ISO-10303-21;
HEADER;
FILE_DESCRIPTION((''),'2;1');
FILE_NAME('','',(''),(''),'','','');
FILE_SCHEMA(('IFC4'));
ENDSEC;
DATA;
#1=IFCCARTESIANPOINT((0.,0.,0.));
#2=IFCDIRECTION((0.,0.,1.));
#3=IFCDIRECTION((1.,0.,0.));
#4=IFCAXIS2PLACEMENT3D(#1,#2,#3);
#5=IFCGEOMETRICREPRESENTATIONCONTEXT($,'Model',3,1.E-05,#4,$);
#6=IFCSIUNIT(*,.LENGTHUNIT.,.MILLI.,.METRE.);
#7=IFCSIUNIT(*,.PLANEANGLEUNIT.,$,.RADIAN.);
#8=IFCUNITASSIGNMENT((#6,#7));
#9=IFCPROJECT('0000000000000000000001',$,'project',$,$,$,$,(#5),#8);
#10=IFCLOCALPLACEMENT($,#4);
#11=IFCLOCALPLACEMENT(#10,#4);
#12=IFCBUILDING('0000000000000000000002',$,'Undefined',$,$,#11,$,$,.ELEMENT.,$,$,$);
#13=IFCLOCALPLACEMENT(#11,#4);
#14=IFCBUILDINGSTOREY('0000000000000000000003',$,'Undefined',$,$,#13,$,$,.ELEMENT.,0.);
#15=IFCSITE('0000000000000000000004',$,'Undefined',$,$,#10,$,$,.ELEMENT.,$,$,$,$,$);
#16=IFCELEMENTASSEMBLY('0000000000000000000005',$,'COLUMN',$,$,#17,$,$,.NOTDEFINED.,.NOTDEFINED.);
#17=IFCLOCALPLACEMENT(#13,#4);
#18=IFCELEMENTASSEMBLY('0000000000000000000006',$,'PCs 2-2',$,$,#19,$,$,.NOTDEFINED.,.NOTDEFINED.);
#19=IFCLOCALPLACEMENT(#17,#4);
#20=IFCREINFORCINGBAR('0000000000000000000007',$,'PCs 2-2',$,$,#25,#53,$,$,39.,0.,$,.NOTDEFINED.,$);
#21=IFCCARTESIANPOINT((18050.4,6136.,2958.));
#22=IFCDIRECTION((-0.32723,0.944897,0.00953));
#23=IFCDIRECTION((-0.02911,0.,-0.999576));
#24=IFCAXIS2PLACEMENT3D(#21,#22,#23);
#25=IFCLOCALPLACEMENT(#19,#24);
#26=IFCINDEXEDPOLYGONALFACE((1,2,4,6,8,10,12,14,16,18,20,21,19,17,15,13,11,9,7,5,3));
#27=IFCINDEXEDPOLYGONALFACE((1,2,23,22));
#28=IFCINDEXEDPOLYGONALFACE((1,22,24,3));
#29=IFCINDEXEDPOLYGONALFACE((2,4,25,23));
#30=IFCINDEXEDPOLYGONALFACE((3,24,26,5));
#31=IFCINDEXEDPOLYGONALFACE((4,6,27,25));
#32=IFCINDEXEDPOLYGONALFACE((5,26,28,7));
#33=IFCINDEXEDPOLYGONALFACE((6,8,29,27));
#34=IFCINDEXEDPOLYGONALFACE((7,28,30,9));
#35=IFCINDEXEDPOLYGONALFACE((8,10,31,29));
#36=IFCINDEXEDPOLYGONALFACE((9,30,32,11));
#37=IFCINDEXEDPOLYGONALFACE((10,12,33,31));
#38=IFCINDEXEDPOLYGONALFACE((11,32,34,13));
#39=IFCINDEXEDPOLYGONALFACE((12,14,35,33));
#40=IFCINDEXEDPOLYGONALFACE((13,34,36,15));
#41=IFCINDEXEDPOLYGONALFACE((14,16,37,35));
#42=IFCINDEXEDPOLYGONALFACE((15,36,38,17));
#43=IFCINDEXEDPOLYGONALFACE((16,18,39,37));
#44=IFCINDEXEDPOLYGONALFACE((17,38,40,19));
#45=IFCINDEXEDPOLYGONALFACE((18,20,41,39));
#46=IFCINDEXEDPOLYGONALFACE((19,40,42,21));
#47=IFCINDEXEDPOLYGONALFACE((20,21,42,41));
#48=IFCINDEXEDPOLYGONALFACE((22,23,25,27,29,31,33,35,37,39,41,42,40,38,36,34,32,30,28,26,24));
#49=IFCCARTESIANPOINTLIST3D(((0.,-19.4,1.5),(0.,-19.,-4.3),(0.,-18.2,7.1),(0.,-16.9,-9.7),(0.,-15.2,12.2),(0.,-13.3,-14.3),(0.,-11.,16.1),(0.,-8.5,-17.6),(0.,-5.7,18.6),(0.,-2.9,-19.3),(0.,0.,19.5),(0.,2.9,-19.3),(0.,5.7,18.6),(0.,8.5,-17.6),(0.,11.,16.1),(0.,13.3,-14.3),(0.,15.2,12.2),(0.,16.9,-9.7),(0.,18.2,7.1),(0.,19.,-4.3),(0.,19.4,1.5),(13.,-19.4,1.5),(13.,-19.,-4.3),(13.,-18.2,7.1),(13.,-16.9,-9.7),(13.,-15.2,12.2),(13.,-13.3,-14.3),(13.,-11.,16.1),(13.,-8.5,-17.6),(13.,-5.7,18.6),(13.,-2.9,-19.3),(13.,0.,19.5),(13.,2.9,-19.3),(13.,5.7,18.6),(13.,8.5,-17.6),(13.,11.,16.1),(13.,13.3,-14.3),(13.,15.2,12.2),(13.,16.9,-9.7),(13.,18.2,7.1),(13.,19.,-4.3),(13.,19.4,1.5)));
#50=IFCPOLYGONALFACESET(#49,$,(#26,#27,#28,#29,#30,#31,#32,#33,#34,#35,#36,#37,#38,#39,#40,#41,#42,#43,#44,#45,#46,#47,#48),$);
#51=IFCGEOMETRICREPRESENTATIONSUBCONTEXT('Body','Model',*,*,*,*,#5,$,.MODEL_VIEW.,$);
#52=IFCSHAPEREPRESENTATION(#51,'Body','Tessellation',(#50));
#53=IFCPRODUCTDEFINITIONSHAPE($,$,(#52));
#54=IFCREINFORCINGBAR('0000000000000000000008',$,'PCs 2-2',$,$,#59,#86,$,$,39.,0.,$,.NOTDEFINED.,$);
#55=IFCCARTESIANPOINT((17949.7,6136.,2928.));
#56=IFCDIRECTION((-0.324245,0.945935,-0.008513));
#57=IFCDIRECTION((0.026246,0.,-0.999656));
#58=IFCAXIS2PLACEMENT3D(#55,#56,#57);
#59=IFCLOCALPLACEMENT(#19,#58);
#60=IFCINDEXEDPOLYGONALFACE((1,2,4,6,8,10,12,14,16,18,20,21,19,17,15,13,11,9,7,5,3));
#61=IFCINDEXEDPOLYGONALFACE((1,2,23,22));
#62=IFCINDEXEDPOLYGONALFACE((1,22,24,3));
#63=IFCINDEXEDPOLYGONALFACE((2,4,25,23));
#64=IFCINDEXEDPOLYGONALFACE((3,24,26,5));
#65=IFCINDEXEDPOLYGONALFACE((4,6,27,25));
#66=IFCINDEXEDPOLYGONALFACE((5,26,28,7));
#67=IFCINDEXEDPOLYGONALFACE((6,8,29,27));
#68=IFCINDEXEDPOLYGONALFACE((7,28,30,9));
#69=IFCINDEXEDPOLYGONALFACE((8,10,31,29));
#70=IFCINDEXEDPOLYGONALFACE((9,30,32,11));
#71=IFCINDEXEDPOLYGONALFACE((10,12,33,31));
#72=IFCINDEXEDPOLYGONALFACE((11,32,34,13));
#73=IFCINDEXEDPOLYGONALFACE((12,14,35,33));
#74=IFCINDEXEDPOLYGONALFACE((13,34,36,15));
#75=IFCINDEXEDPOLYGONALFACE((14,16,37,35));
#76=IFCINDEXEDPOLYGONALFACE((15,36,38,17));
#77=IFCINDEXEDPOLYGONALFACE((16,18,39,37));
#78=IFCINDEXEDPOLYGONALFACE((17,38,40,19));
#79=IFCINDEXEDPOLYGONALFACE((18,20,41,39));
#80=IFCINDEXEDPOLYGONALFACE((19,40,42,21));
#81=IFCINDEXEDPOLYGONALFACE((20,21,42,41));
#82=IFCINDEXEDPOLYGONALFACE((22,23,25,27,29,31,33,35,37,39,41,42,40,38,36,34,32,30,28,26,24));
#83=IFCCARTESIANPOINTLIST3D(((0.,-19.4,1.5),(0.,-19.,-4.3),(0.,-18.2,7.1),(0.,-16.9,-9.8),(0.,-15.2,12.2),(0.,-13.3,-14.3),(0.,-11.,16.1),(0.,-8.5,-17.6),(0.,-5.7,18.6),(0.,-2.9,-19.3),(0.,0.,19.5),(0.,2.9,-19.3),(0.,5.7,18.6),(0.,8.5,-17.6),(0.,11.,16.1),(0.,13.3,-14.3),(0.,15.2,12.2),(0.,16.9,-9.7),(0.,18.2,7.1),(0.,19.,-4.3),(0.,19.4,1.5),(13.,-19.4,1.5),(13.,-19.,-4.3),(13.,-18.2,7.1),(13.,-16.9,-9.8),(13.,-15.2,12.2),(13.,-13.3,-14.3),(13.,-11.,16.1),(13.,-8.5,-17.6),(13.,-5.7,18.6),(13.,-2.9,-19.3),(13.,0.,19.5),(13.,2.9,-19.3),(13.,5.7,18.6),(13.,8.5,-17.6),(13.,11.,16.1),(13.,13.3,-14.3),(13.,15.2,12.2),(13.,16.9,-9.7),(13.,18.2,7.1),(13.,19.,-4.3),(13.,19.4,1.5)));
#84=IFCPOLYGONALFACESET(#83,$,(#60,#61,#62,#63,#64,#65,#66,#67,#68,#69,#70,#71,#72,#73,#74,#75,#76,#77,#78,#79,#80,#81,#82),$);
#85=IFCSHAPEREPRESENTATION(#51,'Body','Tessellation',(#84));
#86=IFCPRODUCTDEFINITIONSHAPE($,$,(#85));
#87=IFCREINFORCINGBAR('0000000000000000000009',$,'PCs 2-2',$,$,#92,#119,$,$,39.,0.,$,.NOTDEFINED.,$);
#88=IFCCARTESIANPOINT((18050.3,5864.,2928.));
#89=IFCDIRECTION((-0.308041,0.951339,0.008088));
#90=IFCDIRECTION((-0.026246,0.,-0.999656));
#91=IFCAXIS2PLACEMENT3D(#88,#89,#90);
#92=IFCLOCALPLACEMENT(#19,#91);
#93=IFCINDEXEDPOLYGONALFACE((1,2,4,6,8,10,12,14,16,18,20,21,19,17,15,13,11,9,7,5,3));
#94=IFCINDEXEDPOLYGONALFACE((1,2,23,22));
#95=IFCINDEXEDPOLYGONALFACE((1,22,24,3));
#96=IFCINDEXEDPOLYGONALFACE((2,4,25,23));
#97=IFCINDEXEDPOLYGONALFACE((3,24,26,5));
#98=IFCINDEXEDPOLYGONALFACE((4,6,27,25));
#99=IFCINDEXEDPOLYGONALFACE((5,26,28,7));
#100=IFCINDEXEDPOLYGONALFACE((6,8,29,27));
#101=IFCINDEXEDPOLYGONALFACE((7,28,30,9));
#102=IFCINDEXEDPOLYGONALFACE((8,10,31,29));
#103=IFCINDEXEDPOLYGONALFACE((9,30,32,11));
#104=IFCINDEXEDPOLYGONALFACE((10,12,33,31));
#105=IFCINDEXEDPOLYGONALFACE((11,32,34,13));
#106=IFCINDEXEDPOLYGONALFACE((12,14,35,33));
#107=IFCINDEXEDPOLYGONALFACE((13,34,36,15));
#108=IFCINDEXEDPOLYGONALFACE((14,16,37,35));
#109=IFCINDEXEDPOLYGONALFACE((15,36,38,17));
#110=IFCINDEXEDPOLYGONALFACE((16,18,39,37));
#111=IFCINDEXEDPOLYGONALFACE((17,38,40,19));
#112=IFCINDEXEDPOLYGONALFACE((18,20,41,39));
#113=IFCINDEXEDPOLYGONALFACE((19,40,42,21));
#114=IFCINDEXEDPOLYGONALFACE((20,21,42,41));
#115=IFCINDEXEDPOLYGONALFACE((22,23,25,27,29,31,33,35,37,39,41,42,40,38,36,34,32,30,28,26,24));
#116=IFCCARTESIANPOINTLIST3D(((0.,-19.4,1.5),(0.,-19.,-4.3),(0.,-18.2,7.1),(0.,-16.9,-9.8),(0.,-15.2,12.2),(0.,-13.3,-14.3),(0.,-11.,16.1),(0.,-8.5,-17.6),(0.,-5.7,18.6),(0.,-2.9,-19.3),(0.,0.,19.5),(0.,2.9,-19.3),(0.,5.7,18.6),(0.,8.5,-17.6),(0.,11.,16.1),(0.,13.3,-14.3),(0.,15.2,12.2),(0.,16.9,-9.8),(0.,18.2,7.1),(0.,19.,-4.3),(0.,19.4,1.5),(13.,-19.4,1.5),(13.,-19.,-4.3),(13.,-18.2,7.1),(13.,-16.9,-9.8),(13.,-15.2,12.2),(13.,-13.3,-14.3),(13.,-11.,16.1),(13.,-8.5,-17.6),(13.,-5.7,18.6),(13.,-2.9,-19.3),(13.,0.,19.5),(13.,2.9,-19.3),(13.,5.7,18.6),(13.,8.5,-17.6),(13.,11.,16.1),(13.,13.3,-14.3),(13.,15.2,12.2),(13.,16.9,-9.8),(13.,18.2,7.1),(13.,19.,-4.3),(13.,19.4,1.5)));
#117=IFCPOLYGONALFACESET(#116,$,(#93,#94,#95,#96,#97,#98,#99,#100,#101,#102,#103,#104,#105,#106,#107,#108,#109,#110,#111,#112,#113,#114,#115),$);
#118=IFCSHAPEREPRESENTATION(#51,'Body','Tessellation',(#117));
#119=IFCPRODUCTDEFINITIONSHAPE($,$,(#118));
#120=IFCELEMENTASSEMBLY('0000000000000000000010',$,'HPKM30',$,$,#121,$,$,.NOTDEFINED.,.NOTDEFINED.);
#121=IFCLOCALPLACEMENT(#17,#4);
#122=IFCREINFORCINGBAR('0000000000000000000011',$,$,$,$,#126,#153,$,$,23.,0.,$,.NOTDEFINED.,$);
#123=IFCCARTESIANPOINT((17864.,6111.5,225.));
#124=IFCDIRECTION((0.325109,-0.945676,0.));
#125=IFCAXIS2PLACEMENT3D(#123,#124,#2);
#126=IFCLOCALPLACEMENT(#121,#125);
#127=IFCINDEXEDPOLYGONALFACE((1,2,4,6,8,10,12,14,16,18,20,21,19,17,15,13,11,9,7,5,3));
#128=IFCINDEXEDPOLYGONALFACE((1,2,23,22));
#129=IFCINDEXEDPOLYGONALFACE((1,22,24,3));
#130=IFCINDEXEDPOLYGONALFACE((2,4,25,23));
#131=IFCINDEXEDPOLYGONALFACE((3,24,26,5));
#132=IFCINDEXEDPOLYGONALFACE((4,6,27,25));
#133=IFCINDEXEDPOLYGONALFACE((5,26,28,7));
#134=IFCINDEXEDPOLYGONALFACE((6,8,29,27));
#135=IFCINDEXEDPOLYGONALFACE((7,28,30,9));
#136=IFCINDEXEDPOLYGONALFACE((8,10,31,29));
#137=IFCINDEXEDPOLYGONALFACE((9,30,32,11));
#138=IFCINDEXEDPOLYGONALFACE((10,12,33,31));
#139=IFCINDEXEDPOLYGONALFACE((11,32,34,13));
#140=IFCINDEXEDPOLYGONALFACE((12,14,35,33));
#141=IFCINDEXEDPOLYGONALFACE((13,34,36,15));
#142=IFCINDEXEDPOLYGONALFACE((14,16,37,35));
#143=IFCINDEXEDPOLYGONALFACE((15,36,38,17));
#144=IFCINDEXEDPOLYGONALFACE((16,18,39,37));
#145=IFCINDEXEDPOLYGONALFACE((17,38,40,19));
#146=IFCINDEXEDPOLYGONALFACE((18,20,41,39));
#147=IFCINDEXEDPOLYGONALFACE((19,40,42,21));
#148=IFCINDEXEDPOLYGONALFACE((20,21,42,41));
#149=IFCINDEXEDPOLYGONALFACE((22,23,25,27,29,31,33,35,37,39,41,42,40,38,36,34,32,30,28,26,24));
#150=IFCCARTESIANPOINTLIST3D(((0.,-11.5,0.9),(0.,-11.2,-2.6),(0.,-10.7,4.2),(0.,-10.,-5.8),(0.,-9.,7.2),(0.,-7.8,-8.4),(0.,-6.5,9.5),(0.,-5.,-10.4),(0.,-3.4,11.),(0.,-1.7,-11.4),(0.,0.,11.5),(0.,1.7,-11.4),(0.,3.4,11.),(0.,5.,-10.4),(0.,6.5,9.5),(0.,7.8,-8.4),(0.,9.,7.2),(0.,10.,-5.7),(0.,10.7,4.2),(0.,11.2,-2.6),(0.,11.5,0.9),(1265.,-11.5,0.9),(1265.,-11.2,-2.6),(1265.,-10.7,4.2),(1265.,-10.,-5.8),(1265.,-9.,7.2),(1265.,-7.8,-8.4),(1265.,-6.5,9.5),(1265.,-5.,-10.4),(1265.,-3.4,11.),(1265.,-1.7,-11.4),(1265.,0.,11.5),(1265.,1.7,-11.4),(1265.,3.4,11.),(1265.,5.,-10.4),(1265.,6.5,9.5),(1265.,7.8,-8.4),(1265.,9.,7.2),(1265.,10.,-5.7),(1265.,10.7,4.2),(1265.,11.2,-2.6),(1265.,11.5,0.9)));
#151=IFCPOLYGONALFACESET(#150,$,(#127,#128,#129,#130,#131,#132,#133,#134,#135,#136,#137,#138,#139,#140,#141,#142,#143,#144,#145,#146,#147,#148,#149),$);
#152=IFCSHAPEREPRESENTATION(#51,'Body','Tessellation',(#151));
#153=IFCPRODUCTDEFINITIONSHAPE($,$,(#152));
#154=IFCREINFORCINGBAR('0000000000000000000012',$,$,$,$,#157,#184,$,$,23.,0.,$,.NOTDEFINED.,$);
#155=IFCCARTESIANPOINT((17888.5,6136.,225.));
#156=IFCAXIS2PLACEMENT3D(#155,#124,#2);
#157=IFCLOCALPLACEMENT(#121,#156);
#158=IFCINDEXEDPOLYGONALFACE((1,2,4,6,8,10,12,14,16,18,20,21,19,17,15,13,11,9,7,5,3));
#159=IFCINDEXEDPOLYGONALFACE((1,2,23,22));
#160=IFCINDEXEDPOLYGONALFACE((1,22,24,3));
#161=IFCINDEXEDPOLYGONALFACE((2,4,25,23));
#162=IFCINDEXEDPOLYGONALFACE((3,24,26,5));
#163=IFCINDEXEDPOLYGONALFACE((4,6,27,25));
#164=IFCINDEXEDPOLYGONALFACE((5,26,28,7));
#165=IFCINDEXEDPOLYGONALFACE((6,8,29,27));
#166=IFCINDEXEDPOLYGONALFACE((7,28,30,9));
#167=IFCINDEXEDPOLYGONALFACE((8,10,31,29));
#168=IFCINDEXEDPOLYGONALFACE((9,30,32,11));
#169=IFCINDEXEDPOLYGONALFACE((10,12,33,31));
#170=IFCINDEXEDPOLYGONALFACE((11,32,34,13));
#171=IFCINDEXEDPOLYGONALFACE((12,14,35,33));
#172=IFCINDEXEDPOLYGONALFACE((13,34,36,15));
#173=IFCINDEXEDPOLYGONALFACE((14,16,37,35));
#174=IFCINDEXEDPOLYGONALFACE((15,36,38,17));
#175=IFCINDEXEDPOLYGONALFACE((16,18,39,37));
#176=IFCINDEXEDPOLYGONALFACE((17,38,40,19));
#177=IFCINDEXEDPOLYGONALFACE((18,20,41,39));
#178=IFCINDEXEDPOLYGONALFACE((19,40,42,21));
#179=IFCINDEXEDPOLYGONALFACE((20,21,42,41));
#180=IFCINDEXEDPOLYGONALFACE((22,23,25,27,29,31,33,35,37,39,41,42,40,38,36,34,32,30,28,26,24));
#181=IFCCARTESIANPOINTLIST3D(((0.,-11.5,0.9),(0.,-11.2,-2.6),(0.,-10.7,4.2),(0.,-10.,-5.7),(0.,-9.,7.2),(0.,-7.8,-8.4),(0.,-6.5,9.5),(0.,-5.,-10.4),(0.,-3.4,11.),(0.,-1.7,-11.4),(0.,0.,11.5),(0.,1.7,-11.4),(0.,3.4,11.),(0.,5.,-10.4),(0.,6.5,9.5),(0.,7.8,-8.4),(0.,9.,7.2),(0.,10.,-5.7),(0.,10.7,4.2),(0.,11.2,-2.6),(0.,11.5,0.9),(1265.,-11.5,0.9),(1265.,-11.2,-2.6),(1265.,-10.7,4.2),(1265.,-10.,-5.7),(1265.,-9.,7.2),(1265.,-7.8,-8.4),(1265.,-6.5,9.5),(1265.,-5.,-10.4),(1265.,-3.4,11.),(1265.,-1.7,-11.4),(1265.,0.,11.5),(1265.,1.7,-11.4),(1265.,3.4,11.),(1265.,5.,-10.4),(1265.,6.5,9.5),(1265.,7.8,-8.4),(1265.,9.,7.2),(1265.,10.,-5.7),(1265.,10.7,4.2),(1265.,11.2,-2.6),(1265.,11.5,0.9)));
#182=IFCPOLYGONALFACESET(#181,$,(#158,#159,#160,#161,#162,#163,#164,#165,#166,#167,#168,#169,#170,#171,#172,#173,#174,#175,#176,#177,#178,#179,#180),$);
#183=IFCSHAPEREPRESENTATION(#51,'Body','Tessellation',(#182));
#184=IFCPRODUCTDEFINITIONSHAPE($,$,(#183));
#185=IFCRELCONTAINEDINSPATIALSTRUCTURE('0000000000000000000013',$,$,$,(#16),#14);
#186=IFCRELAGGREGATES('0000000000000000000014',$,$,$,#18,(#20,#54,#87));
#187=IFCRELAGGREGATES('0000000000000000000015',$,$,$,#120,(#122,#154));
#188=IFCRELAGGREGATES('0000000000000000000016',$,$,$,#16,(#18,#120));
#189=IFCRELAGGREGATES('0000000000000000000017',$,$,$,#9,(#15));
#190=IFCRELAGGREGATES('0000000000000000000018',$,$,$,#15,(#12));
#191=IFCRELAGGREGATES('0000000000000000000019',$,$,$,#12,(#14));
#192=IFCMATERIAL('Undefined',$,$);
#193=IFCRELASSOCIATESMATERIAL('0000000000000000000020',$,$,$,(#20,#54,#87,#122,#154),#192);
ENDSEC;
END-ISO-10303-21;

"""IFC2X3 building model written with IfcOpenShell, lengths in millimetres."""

from ifc_helpers import new_model, entity, si_unit, frame, origin_with_axes, place, context, subcontext, project, spatial, source, transform, mapped, material, element, aggregate, save


model = new_model("IFC2X3")

# Units and contexts
model_context = context("Model", 3, precision=1e-05, world=origin_with_axes())
body_context = subcontext(model_context, "Body", "Model", "MODEL_VIEW")
ifc_project = project(units=[si_unit("LENGTHUNIT", "METRE", prefix="MILLI"), si_unit("PLANEANGLEUNIT", "RADIAN")], contexts=[model_context])

# Site, building, storey
site_placement = place(None, origin_with_axes())
site = spatial("IfcSite", under=ifc_project, at=site_placement, Name="Undefined", CompositionType="ELEMENT")
building_placement = place(site_placement, origin_with_axes())
building = spatial("IfcBuilding", under=site, at=building_placement, Name="Undefined", CompositionType="ELEMENT")
storey_placement = place(building_placement, origin_with_axes())
storey = spatial("IfcBuildingStorey", under=building, at=storey_placement, Name="Undefined", CompositionType="ELEMENT", Elevation=0.0)

# Element assemblies
assembly_1_placement = place(storey_placement, origin_with_axes())
assembly_1 = element("IfcElementAssembly", 1, at=assembly_1_placement, inside=storey, Name="COLUMN", AssemblyPlace="NOTDEFINED", PredefinedType="NOTDEFINED")
assembly_2_placement = place(assembly_1_placement, origin_with_axes())
assembly_2 = element("IfcElementAssembly", 2, at=assembly_2_placement, Name="PCs 2-2", AssemblyPlace="NOTDEFINED", PredefinedType="NOTDEFINED")

# Reinforcing bars
ifc_material_1 = material(Name="Undefined")
shared_shape_1 = source(origin_with_axes(), body_context, "Body", "AdvancedSweptSolid", [
    entity("IfcSweptDiskSolid", entity("IfcTrimmedCurve", entity("IfcLine", entity("IfcCartesianPoint", [0.0, 0.0, 0.0]), entity("IfcVector", entity("IfcDirection", [1.0, 0.0, 0.0]), 1.0)), [entity("IfcParameterValue", 0.0)], [entity("IfcParameterValue", 13.0)], True, "PARAMETER"), 19.5, None, 0.0, 13.0),
])
reinforcing_bar_1_placement = place(assembly_2_placement, frame((18050.4, 6136.0, 2958.0), z_axis=(-0.32723, 0.944897, 0.00953), x_axis=(-0.02911, 0.0, -0.999576)))
reinforcing_bar_1 = element("IfcReinforcingBar", 3, at=reinforcing_bar_1_placement, material=ifc_material_1, Name="PCs 2-2", BarRole="NOTDEFINED", CrossSectionArea=0.0, NominalDiameter=39.0, context=body_context, shape_type="MappedRepresentation", body=[
    mapped(shared_shape_1, transform((0.0, 0.0, 0.0))),
])
shared_shape_2 = source(origin_with_axes(), body_context, "Body", "AdvancedSweptSolid", [
    entity("IfcSweptDiskSolid", entity("IfcTrimmedCurve", entity("IfcLine", entity("IfcCartesianPoint", [0.0, 0.0, 0.0]), entity("IfcVector", entity("IfcDirection", [1.0, 0.0, 0.0]), 1.0)), [entity("IfcParameterValue", 0.0)], [entity("IfcParameterValue", 13.0)], True, "PARAMETER"), 19.5, None, 0.0, 13.0),
])
reinforcing_bar_2_placement = place(assembly_2_placement, frame((17949.7, 6136.0, 2928.0), z_axis=(-0.324245, 0.945935, -0.008513), x_axis=(0.026246, 0.0, -0.999656)))
reinforcing_bar_2 = element("IfcReinforcingBar", 4, at=reinforcing_bar_2_placement, material=ifc_material_1, Name="PCs 2-2", BarRole="NOTDEFINED", CrossSectionArea=0.0, NominalDiameter=39.0, context=body_context, shape_type="MappedRepresentation", body=[
    mapped(shared_shape_2, transform((0.0, 0.0, 0.0))),
])
shared_shape_3 = source(origin_with_axes(), body_context, "Body", "AdvancedSweptSolid", [
    entity("IfcSweptDiskSolid", entity("IfcTrimmedCurve", entity("IfcLine", entity("IfcCartesianPoint", [0.0, 0.0, 0.0]), entity("IfcVector", entity("IfcDirection", [1.0, 0.0, 0.0]), 1.0)), [entity("IfcParameterValue", 0.0)], [entity("IfcParameterValue", 13.0)], True, "PARAMETER"), 19.5, None, 0.0, 13.0),
])
reinforcing_bar_3_placement = place(assembly_2_placement, frame((18050.3, 5864.0, 2928.0), z_axis=(-0.308041, 0.951339, 0.008088), x_axis=(-0.026246, 0.0, -0.999656)))
reinforcing_bar_3 = element("IfcReinforcingBar", 5, at=reinforcing_bar_3_placement, material=ifc_material_1, Name="PCs 2-2", BarRole="NOTDEFINED", CrossSectionArea=0.0, NominalDiameter=39.0, context=body_context, shape_type="MappedRepresentation", body=[
    mapped(shared_shape_3, transform((0.0, 0.0, 0.0))),
])
aggregate(assembly_2, [reinforcing_bar_1, reinforcing_bar_2, reinforcing_bar_3])

# Element assembly, reinforcing bars
assembly_3_placement = place(assembly_1_placement, origin_with_axes())
assembly_3 = element("IfcElementAssembly", 6, at=assembly_3_placement, Name="HPKM30", AssemblyPlace="NOTDEFINED", PredefinedType="NOTDEFINED")
shared_shape_4 = source(origin_with_axes(), body_context, "Body", "AdvancedSweptSolid", [
    entity("IfcSweptDiskSolid", entity("IfcTrimmedCurve", entity("IfcLine", entity("IfcCartesianPoint", [0.0, 0.0, 0.0]), entity("IfcVector", entity("IfcDirection", [1.0, 0.0, 0.0]), 1.0)), [entity("IfcParameterValue", 0.0)], [entity("IfcParameterValue", 1265.0)], True, "PARAMETER"), 11.5, None, 0.0, 1265.0),
])
reinforcing_bar_4_placement = place(assembly_3_placement, frame((17864.0, 6111.5, 225.0), z_axis=(0.325109, -0.945676, 0.0), x_axis=(0.0, 0.0, 1.0)))
reinforcing_bar_4 = element("IfcReinforcingBar", 7, at=reinforcing_bar_4_placement, material=ifc_material_1, BarRole="NOTDEFINED", CrossSectionArea=0.0, NominalDiameter=23.0, context=body_context, shape_type="MappedRepresentation", body=[
    mapped(shared_shape_4, transform((0.0, 0.0, 0.0))),
])
shared_shape_5 = source(origin_with_axes(), body_context, "Body", "AdvancedSweptSolid", [
    entity("IfcSweptDiskSolid", entity("IfcTrimmedCurve", entity("IfcLine", entity("IfcCartesianPoint", [0.0, 0.0, 0.0]), entity("IfcVector", entity("IfcDirection", [1.0, 0.0, 0.0]), 1.0)), [entity("IfcParameterValue", 0.0)], [entity("IfcParameterValue", 1265.0)], True, "PARAMETER"), 11.5, None, 0.0, 1265.0),
])
reinforcing_bar_5_placement = place(assembly_3_placement, frame((17888.5, 6136.0, 225.0), z_axis=(0.325109, -0.945676, 0.0), x_axis=(0.0, 0.0, 1.0)))
reinforcing_bar_5 = element("IfcReinforcingBar", 8, at=reinforcing_bar_5_placement, material=ifc_material_1, BarRole="NOTDEFINED", CrossSectionArea=0.0, NominalDiameter=23.0, context=body_context, shape_type="MappedRepresentation", body=[
    mapped(shared_shape_5, transform((0.0, 0.0, 0.0))),
])
aggregate(assembly_3, [reinforcing_bar_4, reinforcing_bar_5])

aggregate(assembly_1, [assembly_2, assembly_3])

save(model, "model.ifc")
